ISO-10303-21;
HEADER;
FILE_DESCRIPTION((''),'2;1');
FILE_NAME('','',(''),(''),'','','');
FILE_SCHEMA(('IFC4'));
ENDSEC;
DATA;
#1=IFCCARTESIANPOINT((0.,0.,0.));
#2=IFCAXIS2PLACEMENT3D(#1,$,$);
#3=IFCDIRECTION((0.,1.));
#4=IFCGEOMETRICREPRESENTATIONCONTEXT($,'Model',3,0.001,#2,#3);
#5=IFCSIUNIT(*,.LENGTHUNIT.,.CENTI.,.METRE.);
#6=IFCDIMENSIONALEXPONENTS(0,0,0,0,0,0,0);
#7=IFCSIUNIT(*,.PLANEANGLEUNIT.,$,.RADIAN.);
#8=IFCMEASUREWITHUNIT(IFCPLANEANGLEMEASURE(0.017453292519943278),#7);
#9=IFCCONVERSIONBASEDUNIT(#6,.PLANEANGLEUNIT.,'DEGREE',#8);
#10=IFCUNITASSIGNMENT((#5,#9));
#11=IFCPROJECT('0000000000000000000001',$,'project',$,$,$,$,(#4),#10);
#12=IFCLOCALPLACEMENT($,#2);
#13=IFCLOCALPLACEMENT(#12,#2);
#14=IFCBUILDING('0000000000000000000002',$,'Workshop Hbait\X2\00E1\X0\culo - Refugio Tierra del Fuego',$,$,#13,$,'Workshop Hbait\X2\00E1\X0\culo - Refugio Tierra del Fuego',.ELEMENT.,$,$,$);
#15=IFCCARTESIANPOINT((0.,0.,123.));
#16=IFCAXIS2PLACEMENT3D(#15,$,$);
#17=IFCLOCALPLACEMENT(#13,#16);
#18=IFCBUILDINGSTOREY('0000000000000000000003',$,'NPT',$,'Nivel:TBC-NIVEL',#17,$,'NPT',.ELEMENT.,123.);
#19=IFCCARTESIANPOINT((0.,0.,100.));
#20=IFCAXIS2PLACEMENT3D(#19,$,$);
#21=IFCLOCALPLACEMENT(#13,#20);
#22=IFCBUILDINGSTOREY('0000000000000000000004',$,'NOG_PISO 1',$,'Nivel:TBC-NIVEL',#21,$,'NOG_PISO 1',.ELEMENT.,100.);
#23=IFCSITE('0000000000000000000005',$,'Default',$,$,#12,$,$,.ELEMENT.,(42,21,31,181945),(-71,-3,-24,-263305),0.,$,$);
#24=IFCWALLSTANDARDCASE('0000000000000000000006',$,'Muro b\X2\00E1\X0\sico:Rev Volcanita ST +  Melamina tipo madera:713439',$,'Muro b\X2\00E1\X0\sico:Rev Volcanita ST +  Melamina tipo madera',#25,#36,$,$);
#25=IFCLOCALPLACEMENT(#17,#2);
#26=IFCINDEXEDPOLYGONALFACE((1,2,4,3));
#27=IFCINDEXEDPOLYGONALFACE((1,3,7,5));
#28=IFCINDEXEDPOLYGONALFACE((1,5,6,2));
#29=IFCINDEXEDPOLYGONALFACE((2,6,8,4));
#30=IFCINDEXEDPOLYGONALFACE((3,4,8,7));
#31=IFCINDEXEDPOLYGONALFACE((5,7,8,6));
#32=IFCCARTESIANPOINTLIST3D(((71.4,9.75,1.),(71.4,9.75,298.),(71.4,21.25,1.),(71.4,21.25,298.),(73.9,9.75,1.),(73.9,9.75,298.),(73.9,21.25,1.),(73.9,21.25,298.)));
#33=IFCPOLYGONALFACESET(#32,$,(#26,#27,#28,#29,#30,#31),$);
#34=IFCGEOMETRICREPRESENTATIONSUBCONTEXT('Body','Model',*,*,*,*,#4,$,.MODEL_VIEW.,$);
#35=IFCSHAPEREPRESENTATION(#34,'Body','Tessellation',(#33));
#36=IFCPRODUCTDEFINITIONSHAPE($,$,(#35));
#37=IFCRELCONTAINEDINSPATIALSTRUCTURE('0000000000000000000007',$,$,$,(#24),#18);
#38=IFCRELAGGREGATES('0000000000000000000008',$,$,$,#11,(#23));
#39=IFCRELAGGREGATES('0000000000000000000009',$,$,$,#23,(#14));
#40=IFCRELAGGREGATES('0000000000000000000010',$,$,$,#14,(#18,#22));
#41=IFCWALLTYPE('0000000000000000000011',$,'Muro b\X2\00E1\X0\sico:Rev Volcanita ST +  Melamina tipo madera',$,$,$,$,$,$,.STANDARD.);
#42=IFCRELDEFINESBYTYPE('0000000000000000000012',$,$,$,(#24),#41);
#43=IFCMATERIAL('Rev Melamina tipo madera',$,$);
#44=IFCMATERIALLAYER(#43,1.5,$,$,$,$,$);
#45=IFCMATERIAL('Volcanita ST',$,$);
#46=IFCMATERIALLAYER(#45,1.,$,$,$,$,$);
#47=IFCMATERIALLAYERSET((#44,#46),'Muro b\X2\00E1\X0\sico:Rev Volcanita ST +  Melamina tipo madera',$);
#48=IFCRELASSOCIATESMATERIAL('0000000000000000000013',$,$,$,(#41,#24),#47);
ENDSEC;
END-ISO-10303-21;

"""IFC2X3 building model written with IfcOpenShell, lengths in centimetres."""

from ifc_helpers import new_model, entity, si_unit, converted_unit, direction, frame, frame_2d, origin, place, context, subcontext, project, spatial, rectangle, extrude, material, layer, layer_set, layer_usage, type_object, element, save


model = new_model("IFC2X3")

# Units and contexts
model_context = context("Model", 3, precision=0.001, world=origin(), true_north=direction((0.0, 1.0)))
body_context = subcontext(model_context, "Body", "Model", "MODEL_VIEW")
ifc_project = project(units=[si_unit("LENGTHUNIT", "METRE", prefix="CENTI"), converted_unit("PLANEANGLEUNIT", "DEGREE", entity("IfcPlaneAngleMeasure", 0.017453292519943278), si_unit("PLANEANGLEUNIT", "RADIAN"), dimensions=[0, 0, 0, 0, 0, 0, 0])], contexts=[model_context])

# Site, building, storey
site_placement = place(None, origin())
site = spatial("IfcSite", under=ifc_project, at=site_placement, Name="Default", CompositionType="ELEMENT", RefLatitude=(42, 21, 31, 181945), RefLongitude=(-71, -3, -24, -263305), RefElevation=0.0)
building_placement = place(site_placement, origin())
building = spatial("IfcBuilding", under=site, at=building_placement, Name="Workshop Hbaitáculo - Refugio Tierra del Fuego", LongName="Workshop Hbaitáculo - Refugio Tierra del Fuego", CompositionType="ELEMENT")
storey_1_placement = place(building_placement, frame((0.0, 0.0, 123.0)))
storey_1 = spatial("IfcBuildingStorey", under=building, at=storey_1_placement, Name="NPT", ObjectType="Nivel:TBC-NIVEL", LongName="NPT", CompositionType="ELEMENT", Elevation=123.0)

# Shared definitions
storey_2_placement = place(building_placement, frame((0.0, 0.0, 100.0)))
storey_2 = spatial("IfcBuildingStorey", under=building, at=storey_2_placement, Name="NOG_PISO 1", ObjectType="Nivel:TBC-NIVEL", LongName="NOG_PISO 1", CompositionType="ELEMENT", Elevation=100.0)

# Wall
ifc_material_1 = material(Name="Rev Melamina tipo madera")
ifc_layer_1 = layer(ifc_material_1, 1.5)
ifc_material_2 = material(Name="Volcanita ST")
ifc_layer_2 = layer(ifc_material_2, 1.0)
ifc_layer_set_1 = layer_set([ifc_layer_1, ifc_layer_2], Name="Muro básico:Rev Volcanita ST +  Melamina tipo madera")
ifc_layer_usage_1 = layer_usage(ifc_layer_set_1, "AXIS2", "NEGATIVE", 1.25)
wall_type_1 = type_object("IfcWallType", Name="Muro básico:Rev Volcanita ST +  Melamina tipo madera", PredefinedType="STANDARD", material=ifc_layer_set_1)
wall_1_placement = place(storey_1_placement, frame((72.65, 21.25, 1.0), z_axis=(0.0, 0.0, 1.0), x_axis=(0.0, -1.0, 0.0)))
element("IfcWallStandardCase", 1, at=wall_1_placement, inside=storey_1, type_object=wall_type_1, material=ifc_layer_usage_1, Name="Muro básico:Rev Volcanita ST +  Melamina tipo madera:713439", ObjectType="Muro básico:Rev Volcanita ST +  Melamina tipo madera", context=body_context, shape_type="SweptSolid", body=[
    extrude(rectangle(XDim=11.5, YDim=2.5, at=frame_2d((5.75, 0.0), x_axis=(-1.0, 0.0))), origin(), (0.0, 0.0, 1.0), 297.0),
])

save(model, "model.ifc")
